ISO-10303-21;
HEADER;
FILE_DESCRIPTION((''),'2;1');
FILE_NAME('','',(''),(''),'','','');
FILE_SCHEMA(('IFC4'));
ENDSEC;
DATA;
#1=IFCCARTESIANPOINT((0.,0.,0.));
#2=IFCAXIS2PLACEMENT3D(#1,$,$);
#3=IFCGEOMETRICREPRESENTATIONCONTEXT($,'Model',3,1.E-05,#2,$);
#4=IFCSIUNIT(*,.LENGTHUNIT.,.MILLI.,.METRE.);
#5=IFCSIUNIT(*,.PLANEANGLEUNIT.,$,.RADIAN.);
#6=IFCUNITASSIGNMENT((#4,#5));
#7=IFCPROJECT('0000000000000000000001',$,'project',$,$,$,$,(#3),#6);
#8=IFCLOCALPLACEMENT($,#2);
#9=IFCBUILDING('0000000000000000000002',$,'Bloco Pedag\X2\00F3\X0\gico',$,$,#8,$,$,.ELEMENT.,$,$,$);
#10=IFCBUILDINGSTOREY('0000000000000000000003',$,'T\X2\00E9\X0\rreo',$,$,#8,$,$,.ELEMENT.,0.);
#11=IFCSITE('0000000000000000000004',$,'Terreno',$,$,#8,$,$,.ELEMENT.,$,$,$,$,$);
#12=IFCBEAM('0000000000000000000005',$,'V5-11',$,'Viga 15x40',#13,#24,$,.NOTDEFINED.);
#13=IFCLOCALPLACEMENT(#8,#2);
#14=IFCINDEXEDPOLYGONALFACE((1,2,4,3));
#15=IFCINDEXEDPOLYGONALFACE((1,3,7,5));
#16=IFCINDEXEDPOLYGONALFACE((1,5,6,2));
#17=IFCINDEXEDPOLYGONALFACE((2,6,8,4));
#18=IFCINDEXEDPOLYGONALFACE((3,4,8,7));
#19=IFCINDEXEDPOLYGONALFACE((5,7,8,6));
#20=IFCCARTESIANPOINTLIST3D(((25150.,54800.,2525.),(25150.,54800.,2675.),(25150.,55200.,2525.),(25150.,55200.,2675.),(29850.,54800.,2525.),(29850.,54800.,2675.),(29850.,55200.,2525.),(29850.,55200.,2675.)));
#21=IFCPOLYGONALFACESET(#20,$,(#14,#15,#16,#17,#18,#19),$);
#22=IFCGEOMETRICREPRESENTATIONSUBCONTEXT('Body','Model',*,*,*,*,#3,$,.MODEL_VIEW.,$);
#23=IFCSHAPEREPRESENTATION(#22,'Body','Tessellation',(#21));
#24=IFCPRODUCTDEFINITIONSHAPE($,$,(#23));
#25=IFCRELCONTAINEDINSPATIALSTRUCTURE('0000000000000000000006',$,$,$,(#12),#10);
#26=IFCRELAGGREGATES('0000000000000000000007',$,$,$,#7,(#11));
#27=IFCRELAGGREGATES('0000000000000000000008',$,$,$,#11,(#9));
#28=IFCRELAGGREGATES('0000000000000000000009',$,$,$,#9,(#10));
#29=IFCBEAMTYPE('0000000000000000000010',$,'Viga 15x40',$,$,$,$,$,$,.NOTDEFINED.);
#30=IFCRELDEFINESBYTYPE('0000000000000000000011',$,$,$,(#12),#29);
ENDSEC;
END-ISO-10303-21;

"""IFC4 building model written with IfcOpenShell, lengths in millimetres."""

from ifc_helpers import new_model, si_unit, frame, origin, origin_2d, place, context, subcontext, project, spatial, rectangle, extrude, type_object, element, save


model = new_model("IFC4")

# Units and contexts
model_context = context("Model", 3, precision=1e-05, world=origin())
body_context = subcontext(model_context, "Body", "Model", "MODEL_VIEW")
ifc_project = project(units=[si_unit("LENGTHUNIT", "METRE", prefix="MILLI"), si_unit("PLANEANGLEUNIT", "RADIAN")], contexts=[model_context])

# Site, building, storey
placement = place(None, origin())
site = spatial("IfcSite", under=ifc_project, at=placement, Name="Terreno", CompositionType="ELEMENT")
building = spatial("IfcBuilding", under=site, at=placement, Name="Bloco Pedagógico", CompositionType="ELEMENT")
storey = spatial("IfcBuildingStorey", under=building, at=placement, Name="Térreo", CompositionType="ELEMENT", Elevation=0.0)

# Beam
beam_type = type_object("IfcBeamType", Name="Viga 15x40", PredefinedType="NOTDEFINED")
for number, where, z_axis, x_axis, name in (
    (1, (25150.0, 55000.0, 2600.0), (1.0, 0.0, 0.0), (0.0, 1.0, 0.0), "V5-11"),
):
    element("IfcBeam", number, at=place(None, frame(where, z_axis=z_axis, x_axis=x_axis)), inside=storey, type_object=beam_type, Name=name, ObjectType="Viga 15x40", PredefinedType="NOTDEFINED", context=body_context, shape_type="SweptSolid", body=[
        extrude(rectangle(XDim=400.0, YDim=150.0, at=origin_2d()), None, (0.0, 0.0, 1.0), 4700.0),
    ])

save(model, "model.ifc")
